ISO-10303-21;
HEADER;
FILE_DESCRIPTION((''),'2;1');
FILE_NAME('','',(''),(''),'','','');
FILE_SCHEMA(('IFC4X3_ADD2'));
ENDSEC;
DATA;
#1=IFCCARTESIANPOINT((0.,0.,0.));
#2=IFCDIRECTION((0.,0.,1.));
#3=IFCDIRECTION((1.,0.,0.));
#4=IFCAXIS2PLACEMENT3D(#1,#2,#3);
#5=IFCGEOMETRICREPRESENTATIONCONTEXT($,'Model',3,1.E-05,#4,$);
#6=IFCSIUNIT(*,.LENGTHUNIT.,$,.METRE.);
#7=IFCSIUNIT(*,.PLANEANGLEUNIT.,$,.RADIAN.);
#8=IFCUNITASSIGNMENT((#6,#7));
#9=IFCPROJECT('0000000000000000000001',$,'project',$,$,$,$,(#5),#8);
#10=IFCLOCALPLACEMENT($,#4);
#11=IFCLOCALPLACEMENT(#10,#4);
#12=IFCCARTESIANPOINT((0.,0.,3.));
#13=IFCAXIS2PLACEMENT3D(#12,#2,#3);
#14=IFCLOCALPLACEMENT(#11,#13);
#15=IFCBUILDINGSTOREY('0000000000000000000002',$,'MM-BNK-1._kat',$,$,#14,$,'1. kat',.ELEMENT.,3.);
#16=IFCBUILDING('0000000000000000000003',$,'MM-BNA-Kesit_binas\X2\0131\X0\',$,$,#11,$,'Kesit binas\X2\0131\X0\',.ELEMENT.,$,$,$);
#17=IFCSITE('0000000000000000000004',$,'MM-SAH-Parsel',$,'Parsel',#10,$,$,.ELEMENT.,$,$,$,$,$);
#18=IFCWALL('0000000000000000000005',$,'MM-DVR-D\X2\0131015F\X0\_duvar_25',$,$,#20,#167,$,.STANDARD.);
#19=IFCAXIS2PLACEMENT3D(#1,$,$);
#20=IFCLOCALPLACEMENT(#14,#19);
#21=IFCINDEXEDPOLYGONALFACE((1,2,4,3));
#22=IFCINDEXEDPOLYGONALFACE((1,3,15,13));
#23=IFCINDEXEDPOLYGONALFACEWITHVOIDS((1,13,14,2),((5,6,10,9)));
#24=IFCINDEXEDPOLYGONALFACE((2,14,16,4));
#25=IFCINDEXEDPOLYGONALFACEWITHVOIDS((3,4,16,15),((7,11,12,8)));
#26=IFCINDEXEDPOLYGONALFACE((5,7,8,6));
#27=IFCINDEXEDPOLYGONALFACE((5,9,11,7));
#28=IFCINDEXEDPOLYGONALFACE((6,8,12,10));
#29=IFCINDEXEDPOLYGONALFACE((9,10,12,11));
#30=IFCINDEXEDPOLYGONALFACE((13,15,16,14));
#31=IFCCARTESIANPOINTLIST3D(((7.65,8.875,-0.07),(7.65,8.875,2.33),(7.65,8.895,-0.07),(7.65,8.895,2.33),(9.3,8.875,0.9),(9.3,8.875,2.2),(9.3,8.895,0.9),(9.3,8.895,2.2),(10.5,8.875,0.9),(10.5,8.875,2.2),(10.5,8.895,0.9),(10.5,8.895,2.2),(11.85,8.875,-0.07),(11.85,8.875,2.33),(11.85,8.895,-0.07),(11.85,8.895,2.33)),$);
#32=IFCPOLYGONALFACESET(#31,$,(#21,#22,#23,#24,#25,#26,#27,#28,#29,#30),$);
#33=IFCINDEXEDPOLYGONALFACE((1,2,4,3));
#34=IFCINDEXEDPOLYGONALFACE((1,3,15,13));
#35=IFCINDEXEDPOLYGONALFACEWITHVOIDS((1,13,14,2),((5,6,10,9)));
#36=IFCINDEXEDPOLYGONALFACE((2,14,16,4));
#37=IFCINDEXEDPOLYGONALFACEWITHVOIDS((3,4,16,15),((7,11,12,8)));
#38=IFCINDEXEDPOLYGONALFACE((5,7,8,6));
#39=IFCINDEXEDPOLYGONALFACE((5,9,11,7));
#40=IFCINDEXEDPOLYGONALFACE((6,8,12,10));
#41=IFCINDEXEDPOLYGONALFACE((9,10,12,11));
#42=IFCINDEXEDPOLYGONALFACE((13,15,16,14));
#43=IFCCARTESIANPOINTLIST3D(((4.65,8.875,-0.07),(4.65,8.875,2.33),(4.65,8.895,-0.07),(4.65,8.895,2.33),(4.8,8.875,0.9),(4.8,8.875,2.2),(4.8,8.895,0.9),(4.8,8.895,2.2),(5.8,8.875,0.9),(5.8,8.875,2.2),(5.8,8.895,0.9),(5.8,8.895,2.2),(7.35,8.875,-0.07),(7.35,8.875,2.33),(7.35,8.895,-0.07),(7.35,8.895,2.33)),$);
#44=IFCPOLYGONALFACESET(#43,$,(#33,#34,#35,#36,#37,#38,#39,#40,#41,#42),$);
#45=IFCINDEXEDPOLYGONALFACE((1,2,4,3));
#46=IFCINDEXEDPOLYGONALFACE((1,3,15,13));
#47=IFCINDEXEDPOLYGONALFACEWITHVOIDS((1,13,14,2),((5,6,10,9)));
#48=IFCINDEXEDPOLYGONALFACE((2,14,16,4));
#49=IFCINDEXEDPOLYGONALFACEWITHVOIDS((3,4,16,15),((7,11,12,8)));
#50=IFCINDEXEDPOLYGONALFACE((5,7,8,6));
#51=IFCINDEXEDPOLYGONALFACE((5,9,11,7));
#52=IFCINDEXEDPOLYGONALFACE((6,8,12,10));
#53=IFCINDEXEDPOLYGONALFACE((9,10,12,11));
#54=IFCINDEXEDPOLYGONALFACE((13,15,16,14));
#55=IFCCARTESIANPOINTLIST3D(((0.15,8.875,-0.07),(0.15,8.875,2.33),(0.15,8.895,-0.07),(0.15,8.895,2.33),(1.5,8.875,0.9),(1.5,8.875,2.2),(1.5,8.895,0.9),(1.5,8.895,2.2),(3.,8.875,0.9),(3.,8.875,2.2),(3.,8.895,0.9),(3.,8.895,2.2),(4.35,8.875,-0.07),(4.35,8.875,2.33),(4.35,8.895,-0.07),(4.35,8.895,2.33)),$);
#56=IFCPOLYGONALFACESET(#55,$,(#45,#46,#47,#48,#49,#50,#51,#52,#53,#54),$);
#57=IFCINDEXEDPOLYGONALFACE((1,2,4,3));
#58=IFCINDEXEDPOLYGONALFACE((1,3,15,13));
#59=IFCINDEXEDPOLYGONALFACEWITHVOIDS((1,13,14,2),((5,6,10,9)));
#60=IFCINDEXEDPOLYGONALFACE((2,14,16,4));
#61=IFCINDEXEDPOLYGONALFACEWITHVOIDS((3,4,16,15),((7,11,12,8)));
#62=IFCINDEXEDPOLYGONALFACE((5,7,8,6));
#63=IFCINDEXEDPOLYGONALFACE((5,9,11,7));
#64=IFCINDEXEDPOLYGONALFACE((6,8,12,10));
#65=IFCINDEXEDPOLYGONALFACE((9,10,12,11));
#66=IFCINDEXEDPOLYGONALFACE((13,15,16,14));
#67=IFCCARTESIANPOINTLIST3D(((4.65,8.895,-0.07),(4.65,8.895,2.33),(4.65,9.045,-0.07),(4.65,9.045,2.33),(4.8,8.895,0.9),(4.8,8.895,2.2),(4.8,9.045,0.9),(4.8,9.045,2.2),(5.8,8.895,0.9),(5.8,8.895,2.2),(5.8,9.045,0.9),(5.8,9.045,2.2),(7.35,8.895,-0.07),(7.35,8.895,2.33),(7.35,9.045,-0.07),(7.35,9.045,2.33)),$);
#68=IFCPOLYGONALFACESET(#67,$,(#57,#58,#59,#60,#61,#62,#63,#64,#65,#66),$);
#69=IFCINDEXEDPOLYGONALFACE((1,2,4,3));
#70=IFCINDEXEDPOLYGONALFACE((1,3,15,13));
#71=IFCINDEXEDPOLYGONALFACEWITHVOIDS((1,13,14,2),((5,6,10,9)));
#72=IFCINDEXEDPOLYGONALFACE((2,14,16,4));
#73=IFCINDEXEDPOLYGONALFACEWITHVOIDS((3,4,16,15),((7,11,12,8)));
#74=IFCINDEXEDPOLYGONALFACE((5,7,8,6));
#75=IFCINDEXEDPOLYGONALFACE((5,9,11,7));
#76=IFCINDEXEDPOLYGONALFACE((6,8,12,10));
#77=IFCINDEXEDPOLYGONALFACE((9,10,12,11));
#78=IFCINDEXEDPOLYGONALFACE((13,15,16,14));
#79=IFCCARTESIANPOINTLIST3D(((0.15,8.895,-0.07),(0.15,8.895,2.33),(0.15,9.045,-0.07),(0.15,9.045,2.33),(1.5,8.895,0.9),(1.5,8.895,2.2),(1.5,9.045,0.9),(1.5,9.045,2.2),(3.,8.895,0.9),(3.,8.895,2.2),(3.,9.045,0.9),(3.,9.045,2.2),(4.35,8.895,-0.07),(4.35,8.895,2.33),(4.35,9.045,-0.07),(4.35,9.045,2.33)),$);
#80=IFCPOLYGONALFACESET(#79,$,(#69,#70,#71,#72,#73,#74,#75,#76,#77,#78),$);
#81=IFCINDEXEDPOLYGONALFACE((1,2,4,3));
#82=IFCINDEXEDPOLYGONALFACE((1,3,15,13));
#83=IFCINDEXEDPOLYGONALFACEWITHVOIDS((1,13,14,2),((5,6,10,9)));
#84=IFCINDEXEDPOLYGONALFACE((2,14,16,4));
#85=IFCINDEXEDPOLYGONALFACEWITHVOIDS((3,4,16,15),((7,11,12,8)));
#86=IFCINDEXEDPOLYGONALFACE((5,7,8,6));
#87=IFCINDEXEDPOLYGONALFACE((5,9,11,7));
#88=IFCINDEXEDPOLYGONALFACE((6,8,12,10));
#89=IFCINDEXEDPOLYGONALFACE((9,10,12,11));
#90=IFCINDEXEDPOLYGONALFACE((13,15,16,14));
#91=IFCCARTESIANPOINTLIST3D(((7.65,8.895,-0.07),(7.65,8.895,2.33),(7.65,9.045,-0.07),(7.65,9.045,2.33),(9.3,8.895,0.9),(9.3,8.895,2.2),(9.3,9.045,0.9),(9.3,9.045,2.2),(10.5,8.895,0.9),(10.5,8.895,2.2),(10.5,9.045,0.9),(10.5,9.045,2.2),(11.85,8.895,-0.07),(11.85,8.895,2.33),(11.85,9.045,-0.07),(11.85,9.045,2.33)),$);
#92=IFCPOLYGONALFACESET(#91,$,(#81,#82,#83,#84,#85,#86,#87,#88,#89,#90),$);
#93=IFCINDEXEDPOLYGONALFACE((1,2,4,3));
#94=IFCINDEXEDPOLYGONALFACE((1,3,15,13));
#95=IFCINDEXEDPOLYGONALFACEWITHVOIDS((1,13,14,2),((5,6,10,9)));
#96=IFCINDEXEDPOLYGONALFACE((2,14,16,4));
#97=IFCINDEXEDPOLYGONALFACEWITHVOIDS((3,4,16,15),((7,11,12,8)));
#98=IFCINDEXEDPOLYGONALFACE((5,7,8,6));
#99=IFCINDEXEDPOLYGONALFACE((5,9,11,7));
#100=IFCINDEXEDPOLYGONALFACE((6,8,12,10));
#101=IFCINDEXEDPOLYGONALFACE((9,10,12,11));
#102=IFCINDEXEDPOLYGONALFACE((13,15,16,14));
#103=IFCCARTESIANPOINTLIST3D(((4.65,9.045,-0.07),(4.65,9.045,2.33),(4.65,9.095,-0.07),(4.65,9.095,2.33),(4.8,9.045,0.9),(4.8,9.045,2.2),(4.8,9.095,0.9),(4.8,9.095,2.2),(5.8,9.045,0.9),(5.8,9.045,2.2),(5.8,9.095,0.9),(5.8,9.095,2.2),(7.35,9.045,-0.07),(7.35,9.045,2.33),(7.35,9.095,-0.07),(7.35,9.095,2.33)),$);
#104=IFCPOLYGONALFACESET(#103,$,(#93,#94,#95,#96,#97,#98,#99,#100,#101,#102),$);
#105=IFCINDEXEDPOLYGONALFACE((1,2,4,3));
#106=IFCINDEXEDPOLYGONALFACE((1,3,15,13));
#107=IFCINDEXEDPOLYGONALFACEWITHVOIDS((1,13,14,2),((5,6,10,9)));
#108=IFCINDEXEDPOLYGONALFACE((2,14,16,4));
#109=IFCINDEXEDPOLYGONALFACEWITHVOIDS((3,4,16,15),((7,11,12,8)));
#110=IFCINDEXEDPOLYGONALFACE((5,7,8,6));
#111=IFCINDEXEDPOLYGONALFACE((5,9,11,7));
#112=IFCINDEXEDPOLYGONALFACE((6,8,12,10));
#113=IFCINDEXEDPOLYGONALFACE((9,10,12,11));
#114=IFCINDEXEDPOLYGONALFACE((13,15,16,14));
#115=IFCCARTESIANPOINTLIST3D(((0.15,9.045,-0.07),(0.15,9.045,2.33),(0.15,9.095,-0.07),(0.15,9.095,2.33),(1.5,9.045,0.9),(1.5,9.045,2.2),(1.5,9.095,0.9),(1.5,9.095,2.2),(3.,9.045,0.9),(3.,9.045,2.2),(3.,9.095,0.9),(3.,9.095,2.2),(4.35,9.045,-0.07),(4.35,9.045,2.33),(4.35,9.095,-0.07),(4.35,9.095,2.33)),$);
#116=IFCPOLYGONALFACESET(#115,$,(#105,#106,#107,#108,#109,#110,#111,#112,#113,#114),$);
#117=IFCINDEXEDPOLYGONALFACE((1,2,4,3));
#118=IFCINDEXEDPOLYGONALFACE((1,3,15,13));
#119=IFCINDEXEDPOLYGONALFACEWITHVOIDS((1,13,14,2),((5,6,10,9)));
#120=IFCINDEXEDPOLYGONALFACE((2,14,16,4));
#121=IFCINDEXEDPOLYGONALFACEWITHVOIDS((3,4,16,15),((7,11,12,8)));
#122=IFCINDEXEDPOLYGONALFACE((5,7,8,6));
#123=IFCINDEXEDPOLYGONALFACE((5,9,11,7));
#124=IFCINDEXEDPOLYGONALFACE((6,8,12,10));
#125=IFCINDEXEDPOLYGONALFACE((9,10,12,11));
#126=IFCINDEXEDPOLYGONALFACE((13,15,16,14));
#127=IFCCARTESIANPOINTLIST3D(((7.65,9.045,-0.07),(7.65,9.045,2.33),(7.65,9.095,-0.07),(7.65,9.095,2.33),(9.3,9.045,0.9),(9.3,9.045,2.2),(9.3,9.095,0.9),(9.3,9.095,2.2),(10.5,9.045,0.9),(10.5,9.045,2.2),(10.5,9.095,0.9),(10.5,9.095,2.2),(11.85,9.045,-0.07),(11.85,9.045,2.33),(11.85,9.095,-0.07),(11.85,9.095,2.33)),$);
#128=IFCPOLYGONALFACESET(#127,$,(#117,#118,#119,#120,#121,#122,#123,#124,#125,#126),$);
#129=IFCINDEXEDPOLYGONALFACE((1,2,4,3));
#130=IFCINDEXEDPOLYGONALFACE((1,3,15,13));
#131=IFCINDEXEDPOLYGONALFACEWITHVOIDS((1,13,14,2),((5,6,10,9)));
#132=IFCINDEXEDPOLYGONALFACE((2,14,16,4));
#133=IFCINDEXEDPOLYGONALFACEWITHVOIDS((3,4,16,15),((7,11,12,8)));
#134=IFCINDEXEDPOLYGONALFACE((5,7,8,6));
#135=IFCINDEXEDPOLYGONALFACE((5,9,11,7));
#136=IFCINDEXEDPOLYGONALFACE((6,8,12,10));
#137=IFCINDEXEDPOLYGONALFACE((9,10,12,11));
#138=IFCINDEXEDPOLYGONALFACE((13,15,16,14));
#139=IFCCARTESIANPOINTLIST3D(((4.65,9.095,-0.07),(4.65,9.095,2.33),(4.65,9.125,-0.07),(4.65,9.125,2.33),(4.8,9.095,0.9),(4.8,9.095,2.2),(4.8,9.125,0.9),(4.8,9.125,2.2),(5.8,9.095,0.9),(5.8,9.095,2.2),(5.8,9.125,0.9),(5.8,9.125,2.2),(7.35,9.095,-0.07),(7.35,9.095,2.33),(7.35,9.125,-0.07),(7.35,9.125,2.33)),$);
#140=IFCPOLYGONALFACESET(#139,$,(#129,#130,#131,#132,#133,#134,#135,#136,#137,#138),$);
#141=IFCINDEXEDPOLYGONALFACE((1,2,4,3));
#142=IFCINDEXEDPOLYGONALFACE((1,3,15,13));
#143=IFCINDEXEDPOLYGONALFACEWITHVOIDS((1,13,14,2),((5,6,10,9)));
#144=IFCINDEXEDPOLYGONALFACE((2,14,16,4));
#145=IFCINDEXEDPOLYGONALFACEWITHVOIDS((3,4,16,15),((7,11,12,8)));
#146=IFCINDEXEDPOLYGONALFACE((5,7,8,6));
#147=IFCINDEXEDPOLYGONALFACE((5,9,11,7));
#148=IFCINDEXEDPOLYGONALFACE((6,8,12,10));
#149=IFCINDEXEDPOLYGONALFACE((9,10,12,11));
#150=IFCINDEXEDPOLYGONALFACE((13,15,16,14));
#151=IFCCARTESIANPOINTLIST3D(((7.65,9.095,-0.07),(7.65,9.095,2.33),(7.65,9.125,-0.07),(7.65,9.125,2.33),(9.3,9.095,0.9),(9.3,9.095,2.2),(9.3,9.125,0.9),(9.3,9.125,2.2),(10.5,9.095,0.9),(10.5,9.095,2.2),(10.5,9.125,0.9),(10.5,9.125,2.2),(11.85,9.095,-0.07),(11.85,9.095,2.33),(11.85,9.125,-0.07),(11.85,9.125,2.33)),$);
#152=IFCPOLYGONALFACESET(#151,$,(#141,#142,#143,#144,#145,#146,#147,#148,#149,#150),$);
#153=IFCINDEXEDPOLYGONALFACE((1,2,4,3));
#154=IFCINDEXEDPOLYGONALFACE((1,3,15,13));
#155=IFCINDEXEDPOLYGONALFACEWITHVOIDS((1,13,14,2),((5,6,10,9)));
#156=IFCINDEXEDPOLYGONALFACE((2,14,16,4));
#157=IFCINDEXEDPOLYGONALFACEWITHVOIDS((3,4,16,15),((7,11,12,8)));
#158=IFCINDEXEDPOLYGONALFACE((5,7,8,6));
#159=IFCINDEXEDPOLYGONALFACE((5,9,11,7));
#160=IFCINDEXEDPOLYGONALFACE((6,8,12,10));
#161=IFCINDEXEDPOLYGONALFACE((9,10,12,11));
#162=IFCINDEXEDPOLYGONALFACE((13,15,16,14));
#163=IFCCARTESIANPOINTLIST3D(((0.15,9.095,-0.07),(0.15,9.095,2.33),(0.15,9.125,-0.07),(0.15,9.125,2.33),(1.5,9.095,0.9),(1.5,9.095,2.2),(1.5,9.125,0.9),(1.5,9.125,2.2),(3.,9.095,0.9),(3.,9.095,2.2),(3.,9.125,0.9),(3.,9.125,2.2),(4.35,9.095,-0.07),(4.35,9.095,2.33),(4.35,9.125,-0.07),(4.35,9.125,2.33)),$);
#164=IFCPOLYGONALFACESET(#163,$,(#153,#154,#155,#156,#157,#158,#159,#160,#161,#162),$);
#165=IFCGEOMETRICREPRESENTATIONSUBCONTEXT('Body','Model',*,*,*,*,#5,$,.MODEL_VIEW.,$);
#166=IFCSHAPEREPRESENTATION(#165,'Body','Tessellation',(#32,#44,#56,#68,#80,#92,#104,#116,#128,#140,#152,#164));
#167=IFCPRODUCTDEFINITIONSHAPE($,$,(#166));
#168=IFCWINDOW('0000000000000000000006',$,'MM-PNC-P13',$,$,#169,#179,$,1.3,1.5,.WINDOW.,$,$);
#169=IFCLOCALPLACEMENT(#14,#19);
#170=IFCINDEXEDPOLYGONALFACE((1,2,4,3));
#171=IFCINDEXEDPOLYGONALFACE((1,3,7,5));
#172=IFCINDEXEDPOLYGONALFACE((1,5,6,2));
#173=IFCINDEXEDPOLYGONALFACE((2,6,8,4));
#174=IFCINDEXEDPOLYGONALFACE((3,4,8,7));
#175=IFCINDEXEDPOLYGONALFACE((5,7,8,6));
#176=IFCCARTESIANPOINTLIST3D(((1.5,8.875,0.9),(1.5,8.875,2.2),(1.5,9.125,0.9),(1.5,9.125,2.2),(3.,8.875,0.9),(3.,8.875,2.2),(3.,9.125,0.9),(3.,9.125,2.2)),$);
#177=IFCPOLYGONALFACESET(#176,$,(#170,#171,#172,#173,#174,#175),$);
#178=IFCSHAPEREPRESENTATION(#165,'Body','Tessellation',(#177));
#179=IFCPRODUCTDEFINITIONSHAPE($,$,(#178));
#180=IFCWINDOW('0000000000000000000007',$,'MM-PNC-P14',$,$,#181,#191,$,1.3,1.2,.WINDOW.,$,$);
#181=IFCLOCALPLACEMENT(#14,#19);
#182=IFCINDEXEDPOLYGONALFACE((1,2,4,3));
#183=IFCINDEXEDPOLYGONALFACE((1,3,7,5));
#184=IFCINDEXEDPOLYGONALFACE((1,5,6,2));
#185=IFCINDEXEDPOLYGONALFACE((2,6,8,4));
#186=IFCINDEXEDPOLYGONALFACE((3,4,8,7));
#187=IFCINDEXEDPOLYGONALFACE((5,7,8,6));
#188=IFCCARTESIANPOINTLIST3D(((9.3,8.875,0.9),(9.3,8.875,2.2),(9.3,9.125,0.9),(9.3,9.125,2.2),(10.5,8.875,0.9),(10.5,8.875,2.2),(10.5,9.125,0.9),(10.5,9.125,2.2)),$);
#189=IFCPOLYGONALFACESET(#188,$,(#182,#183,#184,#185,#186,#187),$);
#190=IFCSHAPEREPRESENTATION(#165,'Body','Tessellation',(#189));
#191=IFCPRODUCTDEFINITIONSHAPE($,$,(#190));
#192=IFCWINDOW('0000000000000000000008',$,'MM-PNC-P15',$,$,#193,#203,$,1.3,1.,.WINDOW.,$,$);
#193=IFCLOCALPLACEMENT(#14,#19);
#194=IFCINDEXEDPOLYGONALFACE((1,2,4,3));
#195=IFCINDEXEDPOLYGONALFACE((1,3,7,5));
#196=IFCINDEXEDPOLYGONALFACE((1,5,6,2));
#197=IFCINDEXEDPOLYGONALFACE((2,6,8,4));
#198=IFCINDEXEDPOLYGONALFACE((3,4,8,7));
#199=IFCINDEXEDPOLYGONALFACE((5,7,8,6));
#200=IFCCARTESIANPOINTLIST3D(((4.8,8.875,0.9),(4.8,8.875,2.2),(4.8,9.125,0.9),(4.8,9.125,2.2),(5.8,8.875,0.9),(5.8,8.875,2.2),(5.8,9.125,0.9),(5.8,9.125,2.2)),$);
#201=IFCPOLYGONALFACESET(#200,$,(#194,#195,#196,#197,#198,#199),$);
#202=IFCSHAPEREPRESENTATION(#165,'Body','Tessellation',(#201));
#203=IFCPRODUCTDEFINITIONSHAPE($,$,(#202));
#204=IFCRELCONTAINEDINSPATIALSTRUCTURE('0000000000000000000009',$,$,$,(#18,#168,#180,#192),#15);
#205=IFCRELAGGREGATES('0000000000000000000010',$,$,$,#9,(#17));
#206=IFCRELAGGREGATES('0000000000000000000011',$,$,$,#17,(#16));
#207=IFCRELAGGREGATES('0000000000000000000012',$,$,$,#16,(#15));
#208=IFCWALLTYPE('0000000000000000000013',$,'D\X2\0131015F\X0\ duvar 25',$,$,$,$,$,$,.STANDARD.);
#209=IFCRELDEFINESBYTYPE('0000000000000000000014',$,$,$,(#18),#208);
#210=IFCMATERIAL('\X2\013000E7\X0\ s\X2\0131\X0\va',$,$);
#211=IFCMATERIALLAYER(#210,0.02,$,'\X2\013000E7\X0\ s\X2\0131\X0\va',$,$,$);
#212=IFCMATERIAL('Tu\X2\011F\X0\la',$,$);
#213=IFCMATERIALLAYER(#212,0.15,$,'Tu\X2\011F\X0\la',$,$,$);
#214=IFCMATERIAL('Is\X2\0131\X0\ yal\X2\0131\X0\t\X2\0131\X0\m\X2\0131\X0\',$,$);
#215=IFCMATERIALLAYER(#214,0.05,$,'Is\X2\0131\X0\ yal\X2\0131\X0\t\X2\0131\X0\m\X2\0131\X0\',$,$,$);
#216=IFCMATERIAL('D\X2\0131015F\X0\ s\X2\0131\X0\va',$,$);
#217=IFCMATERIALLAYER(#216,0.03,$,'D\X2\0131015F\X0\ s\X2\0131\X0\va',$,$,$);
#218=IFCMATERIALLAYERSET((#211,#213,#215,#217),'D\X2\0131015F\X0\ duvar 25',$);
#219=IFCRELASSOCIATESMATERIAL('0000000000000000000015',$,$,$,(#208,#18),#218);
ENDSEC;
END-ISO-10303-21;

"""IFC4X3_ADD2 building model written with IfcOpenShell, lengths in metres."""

from ifc_helpers import new_model, si_unit, frame, origin_with_axes, place, context, subcontext, project, spatial, polyline, outline, extrude, material, layer, layer_set, type_object, element, fill, save


model = new_model("IFC4X3_ADD2")

# Units and contexts
model_context = context("Model", 3, precision=1e-05, world=origin_with_axes())
body_context = subcontext(model_context, "Body", "Model", "MODEL_VIEW")
ifc_project = project(units=[si_unit("LENGTHUNIT", "METRE"), si_unit("PLANEANGLEUNIT", "RADIAN")], contexts=[model_context])

# Site, building, storey
site_placement = place(None, origin_with_axes())
site = spatial("IfcSite", under=ifc_project, at=site_placement, Name="MM-SAH-Parsel", ObjectType="Parsel", CompositionType="ELEMENT")
building_placement = place(site_placement, origin_with_axes())
building = spatial("IfcBuilding", under=site, at=building_placement, Name="MM-BNA-Kesit_binası", LongName="Kesit binası", CompositionType="ELEMENT")
storey_placement = place(building_placement, frame((0.0, 0.0, 3.0), z_axis=(0.0, 0.0, 1.0), x_axis=(1.0, 0.0, 0.0)))
storey = spatial("IfcBuildingStorey", under=building, at=storey_placement, Name="MM-BNK-1._kat", LongName="1. kat", CompositionType="ELEMENT", Elevation=3.0)

# Wall, openings, windows
ifc_material_1 = material(Name="İç sıva")
ifc_layer_1 = layer(ifc_material_1, 0.02, Name="İç sıva")
ifc_material_2 = material(Name="Tuğla")
ifc_layer_2 = layer(ifc_material_2, 0.15, Name="Tuğla")
ifc_material_3 = material(Name="Isı yalıtımı")
ifc_layer_3 = layer(ifc_material_3, 0.05, Name="Isı yalıtımı")
ifc_material_4 = material(Name="Dış sıva")
ifc_layer_4 = layer(ifc_material_4, 0.03, Name="Dış sıva")
ifc_layer_set_1 = layer_set([ifc_layer_1, ifc_layer_2, ifc_layer_3, ifc_layer_4], Name="Dış duvar 25")
wall_type_1 = type_object("IfcWallType", Name="Dış duvar 25", PredefinedType="STANDARD", material=ifc_layer_set_1)
wall_1_placement = place(storey_placement, origin_with_axes())
wall_1 = element("IfcWall", 1, at=wall_1_placement, inside=storey, type_object=wall_type_1, material=ifc_layer_set_1, Name="MM-DVR-Dış_duvar_25", PredefinedType="STANDARD", context=body_context, shape_type="SweptSolid", body=[
    extrude(outline(polyline([(11.85, 8.895), (7.65, 8.895), (7.65, 8.875), (11.85, 8.875), (11.85, 8.895)])), frame((0.0, 0.0, -0.07)), (0.0, 0.0, 1.0), 2.4),
    extrude(outline(polyline([(7.35, 8.895), (4.65, 8.895), (4.65, 8.875), (7.35, 8.875), (7.35, 8.895)])), frame((0.0, 0.0, -0.07)), (0.0, 0.0, 1.0), 2.4),
    extrude(outline(polyline([(4.35, 8.895), (0.15, 8.895), (0.15, 8.875), (4.35, 8.875), (4.35, 8.895)])), frame((0.0, 0.0, -0.07)), (0.0, 0.0, 1.0), 2.4),
    extrude(outline(polyline([(7.35, 9.045), (4.65, 9.045), (4.65, 8.895), (7.35, 8.895), (7.35, 9.045)])), frame((0.0, 0.0, -0.07)), (0.0, 0.0, 1.0), 2.4),
    extrude(outline(polyline([(4.35, 9.045), (0.15, 9.045), (0.15, 8.895), (4.35, 8.895), (4.35, 9.045)])), frame((0.0, 0.0, -0.07)), (0.0, 0.0, 1.0), 2.4),
    extrude(outline(polyline([(11.85, 9.045), (7.65, 9.045), (7.65, 8.895), (11.85, 8.895), (11.85, 9.045)])), frame((0.0, 0.0, -0.07)), (0.0, 0.0, 1.0), 2.4),
    extrude(outline(polyline([(7.35, 9.095), (4.65, 9.095), (4.65, 9.045), (7.35, 9.045), (7.35, 9.095)])), frame((0.0, 0.0, -0.07)), (0.0, 0.0, 1.0), 2.4),
    extrude(outline(polyline([(4.35, 9.095), (0.15, 9.095), (0.15, 9.045), (4.35, 9.045), (4.35, 9.095)])), frame((0.0, 0.0, -0.07)), (0.0, 0.0, 1.0), 2.4),
    extrude(outline(polyline([(11.85, 9.095), (7.65, 9.095), (7.65, 9.045), (11.85, 9.045), (11.85, 9.095)])), frame((0.0, 0.0, -0.07)), (0.0, 0.0, 1.0), 2.4),
    extrude(outline(polyline([(7.35, 9.125), (4.65, 9.125), (4.65, 9.095), (7.35, 9.095), (7.35, 9.125)])), frame((0.0, 0.0, -0.07)), (0.0, 0.0, 1.0), 2.4),
    extrude(outline(polyline([(11.85, 9.125), (7.65, 9.125), (7.65, 9.095), (11.85, 9.095), (11.85, 9.125)])), frame((0.0, 0.0, -0.07)), (0.0, 0.0, 1.0), 2.4),
    extrude(outline(polyline([(4.35, 9.125), (0.15, 9.125), (0.15, 9.095), (4.35, 9.095), (4.35, 9.125)])), frame((0.0, 0.0, -0.07)), (0.0, 0.0, 1.0), 2.4),
])
opening_1_placement = place(storey_placement, origin_with_axes())
opening_1 = element("IfcOpeningElement", 2, at=opening_1_placement, cuts=wall_1, PredefinedType="OPENING", context=body_context, shape_type="SweptSolid", body=[
    extrude(outline(polyline([(3.0, 8.875), (1.5, 8.875), (1.5, 9.125), (3.0, 9.125), (3.0, 8.875)])), frame((0.0, 0.0, 0.9)), (0.0, 0.0, 1.0), 1.3),
])
opening_2_placement = place(storey_placement, origin_with_axes())
opening_2 = element("IfcOpeningElement", 3, at=opening_2_placement, cuts=wall_1, PredefinedType="OPENING", context=body_context, shape_type="SweptSolid", body=[
    extrude(outline(polyline([(10.5, 8.875), (9.3, 8.875), (9.3, 9.125), (10.5, 9.125), (10.5, 8.875)])), frame((0.0, 0.0, 0.9)), (0.0, 0.0, 1.0), 1.3),
])
opening_3_placement = place(storey_placement, origin_with_axes())
opening_3 = element("IfcOpeningElement", 4, at=opening_3_placement, cuts=wall_1, PredefinedType="OPENING", context=body_context, shape_type="SweptSolid", body=[
    extrude(outline(polyline([(5.8, 8.875), (4.8, 8.875), (4.8, 9.125), (5.8, 9.125), (5.8, 8.875)])), frame((0.0, 0.0, 0.9)), (0.0, 0.0, 1.0), 1.3),
])
window_1_placement = place(storey_placement, origin_with_axes())
window_1 = element("IfcWindow", 5, at=window_1_placement, inside=storey, Name="MM-PNC-P13", OverallHeight=1.3, OverallWidth=1.5, PredefinedType="WINDOW", context=body_context, shape_type="SweptSolid", body=[
    extrude(outline(polyline([(3.0, 8.875), (1.5, 8.875), (1.5, 9.125), (3.0, 9.125), (3.0, 8.875)])), frame((0.0, 0.0, 0.9)), (0.0, 0.0, 1.0), 1.3),
])
fill(opening_1, window_1)
window_2_placement = place(storey_placement, origin_with_axes())
window_2 = element("IfcWindow", 6, at=window_2_placement, inside=storey, Name="MM-PNC-P14", OverallHeight=1.3, OverallWidth=1.2, PredefinedType="WINDOW", context=body_context, shape_type="SweptSolid", body=[
    extrude(outline(polyline([(10.5, 8.875), (9.3, 8.875), (9.3, 9.125), (10.5, 9.125), (10.5, 8.875)])), frame((0.0, 0.0, 0.9)), (0.0, 0.0, 1.0), 1.3),
])
fill(opening_2, window_2)
window_3_placement = place(storey_placement, origin_with_axes())
window_3 = element("IfcWindow", 7, at=window_3_placement, inside=storey, Name="MM-PNC-P15", OverallHeight=1.3, OverallWidth=1.0, PredefinedType="WINDOW", context=body_context, shape_type="SweptSolid", body=[
    extrude(outline(polyline([(5.8, 8.875), (4.8, 8.875), (4.8, 9.125), (5.8, 9.125), (5.8, 8.875)])), frame((0.0, 0.0, 0.9)), (0.0, 0.0, 1.0), 1.3),
])
fill(opening_3, window_3)

save(model, "model.ifc")
